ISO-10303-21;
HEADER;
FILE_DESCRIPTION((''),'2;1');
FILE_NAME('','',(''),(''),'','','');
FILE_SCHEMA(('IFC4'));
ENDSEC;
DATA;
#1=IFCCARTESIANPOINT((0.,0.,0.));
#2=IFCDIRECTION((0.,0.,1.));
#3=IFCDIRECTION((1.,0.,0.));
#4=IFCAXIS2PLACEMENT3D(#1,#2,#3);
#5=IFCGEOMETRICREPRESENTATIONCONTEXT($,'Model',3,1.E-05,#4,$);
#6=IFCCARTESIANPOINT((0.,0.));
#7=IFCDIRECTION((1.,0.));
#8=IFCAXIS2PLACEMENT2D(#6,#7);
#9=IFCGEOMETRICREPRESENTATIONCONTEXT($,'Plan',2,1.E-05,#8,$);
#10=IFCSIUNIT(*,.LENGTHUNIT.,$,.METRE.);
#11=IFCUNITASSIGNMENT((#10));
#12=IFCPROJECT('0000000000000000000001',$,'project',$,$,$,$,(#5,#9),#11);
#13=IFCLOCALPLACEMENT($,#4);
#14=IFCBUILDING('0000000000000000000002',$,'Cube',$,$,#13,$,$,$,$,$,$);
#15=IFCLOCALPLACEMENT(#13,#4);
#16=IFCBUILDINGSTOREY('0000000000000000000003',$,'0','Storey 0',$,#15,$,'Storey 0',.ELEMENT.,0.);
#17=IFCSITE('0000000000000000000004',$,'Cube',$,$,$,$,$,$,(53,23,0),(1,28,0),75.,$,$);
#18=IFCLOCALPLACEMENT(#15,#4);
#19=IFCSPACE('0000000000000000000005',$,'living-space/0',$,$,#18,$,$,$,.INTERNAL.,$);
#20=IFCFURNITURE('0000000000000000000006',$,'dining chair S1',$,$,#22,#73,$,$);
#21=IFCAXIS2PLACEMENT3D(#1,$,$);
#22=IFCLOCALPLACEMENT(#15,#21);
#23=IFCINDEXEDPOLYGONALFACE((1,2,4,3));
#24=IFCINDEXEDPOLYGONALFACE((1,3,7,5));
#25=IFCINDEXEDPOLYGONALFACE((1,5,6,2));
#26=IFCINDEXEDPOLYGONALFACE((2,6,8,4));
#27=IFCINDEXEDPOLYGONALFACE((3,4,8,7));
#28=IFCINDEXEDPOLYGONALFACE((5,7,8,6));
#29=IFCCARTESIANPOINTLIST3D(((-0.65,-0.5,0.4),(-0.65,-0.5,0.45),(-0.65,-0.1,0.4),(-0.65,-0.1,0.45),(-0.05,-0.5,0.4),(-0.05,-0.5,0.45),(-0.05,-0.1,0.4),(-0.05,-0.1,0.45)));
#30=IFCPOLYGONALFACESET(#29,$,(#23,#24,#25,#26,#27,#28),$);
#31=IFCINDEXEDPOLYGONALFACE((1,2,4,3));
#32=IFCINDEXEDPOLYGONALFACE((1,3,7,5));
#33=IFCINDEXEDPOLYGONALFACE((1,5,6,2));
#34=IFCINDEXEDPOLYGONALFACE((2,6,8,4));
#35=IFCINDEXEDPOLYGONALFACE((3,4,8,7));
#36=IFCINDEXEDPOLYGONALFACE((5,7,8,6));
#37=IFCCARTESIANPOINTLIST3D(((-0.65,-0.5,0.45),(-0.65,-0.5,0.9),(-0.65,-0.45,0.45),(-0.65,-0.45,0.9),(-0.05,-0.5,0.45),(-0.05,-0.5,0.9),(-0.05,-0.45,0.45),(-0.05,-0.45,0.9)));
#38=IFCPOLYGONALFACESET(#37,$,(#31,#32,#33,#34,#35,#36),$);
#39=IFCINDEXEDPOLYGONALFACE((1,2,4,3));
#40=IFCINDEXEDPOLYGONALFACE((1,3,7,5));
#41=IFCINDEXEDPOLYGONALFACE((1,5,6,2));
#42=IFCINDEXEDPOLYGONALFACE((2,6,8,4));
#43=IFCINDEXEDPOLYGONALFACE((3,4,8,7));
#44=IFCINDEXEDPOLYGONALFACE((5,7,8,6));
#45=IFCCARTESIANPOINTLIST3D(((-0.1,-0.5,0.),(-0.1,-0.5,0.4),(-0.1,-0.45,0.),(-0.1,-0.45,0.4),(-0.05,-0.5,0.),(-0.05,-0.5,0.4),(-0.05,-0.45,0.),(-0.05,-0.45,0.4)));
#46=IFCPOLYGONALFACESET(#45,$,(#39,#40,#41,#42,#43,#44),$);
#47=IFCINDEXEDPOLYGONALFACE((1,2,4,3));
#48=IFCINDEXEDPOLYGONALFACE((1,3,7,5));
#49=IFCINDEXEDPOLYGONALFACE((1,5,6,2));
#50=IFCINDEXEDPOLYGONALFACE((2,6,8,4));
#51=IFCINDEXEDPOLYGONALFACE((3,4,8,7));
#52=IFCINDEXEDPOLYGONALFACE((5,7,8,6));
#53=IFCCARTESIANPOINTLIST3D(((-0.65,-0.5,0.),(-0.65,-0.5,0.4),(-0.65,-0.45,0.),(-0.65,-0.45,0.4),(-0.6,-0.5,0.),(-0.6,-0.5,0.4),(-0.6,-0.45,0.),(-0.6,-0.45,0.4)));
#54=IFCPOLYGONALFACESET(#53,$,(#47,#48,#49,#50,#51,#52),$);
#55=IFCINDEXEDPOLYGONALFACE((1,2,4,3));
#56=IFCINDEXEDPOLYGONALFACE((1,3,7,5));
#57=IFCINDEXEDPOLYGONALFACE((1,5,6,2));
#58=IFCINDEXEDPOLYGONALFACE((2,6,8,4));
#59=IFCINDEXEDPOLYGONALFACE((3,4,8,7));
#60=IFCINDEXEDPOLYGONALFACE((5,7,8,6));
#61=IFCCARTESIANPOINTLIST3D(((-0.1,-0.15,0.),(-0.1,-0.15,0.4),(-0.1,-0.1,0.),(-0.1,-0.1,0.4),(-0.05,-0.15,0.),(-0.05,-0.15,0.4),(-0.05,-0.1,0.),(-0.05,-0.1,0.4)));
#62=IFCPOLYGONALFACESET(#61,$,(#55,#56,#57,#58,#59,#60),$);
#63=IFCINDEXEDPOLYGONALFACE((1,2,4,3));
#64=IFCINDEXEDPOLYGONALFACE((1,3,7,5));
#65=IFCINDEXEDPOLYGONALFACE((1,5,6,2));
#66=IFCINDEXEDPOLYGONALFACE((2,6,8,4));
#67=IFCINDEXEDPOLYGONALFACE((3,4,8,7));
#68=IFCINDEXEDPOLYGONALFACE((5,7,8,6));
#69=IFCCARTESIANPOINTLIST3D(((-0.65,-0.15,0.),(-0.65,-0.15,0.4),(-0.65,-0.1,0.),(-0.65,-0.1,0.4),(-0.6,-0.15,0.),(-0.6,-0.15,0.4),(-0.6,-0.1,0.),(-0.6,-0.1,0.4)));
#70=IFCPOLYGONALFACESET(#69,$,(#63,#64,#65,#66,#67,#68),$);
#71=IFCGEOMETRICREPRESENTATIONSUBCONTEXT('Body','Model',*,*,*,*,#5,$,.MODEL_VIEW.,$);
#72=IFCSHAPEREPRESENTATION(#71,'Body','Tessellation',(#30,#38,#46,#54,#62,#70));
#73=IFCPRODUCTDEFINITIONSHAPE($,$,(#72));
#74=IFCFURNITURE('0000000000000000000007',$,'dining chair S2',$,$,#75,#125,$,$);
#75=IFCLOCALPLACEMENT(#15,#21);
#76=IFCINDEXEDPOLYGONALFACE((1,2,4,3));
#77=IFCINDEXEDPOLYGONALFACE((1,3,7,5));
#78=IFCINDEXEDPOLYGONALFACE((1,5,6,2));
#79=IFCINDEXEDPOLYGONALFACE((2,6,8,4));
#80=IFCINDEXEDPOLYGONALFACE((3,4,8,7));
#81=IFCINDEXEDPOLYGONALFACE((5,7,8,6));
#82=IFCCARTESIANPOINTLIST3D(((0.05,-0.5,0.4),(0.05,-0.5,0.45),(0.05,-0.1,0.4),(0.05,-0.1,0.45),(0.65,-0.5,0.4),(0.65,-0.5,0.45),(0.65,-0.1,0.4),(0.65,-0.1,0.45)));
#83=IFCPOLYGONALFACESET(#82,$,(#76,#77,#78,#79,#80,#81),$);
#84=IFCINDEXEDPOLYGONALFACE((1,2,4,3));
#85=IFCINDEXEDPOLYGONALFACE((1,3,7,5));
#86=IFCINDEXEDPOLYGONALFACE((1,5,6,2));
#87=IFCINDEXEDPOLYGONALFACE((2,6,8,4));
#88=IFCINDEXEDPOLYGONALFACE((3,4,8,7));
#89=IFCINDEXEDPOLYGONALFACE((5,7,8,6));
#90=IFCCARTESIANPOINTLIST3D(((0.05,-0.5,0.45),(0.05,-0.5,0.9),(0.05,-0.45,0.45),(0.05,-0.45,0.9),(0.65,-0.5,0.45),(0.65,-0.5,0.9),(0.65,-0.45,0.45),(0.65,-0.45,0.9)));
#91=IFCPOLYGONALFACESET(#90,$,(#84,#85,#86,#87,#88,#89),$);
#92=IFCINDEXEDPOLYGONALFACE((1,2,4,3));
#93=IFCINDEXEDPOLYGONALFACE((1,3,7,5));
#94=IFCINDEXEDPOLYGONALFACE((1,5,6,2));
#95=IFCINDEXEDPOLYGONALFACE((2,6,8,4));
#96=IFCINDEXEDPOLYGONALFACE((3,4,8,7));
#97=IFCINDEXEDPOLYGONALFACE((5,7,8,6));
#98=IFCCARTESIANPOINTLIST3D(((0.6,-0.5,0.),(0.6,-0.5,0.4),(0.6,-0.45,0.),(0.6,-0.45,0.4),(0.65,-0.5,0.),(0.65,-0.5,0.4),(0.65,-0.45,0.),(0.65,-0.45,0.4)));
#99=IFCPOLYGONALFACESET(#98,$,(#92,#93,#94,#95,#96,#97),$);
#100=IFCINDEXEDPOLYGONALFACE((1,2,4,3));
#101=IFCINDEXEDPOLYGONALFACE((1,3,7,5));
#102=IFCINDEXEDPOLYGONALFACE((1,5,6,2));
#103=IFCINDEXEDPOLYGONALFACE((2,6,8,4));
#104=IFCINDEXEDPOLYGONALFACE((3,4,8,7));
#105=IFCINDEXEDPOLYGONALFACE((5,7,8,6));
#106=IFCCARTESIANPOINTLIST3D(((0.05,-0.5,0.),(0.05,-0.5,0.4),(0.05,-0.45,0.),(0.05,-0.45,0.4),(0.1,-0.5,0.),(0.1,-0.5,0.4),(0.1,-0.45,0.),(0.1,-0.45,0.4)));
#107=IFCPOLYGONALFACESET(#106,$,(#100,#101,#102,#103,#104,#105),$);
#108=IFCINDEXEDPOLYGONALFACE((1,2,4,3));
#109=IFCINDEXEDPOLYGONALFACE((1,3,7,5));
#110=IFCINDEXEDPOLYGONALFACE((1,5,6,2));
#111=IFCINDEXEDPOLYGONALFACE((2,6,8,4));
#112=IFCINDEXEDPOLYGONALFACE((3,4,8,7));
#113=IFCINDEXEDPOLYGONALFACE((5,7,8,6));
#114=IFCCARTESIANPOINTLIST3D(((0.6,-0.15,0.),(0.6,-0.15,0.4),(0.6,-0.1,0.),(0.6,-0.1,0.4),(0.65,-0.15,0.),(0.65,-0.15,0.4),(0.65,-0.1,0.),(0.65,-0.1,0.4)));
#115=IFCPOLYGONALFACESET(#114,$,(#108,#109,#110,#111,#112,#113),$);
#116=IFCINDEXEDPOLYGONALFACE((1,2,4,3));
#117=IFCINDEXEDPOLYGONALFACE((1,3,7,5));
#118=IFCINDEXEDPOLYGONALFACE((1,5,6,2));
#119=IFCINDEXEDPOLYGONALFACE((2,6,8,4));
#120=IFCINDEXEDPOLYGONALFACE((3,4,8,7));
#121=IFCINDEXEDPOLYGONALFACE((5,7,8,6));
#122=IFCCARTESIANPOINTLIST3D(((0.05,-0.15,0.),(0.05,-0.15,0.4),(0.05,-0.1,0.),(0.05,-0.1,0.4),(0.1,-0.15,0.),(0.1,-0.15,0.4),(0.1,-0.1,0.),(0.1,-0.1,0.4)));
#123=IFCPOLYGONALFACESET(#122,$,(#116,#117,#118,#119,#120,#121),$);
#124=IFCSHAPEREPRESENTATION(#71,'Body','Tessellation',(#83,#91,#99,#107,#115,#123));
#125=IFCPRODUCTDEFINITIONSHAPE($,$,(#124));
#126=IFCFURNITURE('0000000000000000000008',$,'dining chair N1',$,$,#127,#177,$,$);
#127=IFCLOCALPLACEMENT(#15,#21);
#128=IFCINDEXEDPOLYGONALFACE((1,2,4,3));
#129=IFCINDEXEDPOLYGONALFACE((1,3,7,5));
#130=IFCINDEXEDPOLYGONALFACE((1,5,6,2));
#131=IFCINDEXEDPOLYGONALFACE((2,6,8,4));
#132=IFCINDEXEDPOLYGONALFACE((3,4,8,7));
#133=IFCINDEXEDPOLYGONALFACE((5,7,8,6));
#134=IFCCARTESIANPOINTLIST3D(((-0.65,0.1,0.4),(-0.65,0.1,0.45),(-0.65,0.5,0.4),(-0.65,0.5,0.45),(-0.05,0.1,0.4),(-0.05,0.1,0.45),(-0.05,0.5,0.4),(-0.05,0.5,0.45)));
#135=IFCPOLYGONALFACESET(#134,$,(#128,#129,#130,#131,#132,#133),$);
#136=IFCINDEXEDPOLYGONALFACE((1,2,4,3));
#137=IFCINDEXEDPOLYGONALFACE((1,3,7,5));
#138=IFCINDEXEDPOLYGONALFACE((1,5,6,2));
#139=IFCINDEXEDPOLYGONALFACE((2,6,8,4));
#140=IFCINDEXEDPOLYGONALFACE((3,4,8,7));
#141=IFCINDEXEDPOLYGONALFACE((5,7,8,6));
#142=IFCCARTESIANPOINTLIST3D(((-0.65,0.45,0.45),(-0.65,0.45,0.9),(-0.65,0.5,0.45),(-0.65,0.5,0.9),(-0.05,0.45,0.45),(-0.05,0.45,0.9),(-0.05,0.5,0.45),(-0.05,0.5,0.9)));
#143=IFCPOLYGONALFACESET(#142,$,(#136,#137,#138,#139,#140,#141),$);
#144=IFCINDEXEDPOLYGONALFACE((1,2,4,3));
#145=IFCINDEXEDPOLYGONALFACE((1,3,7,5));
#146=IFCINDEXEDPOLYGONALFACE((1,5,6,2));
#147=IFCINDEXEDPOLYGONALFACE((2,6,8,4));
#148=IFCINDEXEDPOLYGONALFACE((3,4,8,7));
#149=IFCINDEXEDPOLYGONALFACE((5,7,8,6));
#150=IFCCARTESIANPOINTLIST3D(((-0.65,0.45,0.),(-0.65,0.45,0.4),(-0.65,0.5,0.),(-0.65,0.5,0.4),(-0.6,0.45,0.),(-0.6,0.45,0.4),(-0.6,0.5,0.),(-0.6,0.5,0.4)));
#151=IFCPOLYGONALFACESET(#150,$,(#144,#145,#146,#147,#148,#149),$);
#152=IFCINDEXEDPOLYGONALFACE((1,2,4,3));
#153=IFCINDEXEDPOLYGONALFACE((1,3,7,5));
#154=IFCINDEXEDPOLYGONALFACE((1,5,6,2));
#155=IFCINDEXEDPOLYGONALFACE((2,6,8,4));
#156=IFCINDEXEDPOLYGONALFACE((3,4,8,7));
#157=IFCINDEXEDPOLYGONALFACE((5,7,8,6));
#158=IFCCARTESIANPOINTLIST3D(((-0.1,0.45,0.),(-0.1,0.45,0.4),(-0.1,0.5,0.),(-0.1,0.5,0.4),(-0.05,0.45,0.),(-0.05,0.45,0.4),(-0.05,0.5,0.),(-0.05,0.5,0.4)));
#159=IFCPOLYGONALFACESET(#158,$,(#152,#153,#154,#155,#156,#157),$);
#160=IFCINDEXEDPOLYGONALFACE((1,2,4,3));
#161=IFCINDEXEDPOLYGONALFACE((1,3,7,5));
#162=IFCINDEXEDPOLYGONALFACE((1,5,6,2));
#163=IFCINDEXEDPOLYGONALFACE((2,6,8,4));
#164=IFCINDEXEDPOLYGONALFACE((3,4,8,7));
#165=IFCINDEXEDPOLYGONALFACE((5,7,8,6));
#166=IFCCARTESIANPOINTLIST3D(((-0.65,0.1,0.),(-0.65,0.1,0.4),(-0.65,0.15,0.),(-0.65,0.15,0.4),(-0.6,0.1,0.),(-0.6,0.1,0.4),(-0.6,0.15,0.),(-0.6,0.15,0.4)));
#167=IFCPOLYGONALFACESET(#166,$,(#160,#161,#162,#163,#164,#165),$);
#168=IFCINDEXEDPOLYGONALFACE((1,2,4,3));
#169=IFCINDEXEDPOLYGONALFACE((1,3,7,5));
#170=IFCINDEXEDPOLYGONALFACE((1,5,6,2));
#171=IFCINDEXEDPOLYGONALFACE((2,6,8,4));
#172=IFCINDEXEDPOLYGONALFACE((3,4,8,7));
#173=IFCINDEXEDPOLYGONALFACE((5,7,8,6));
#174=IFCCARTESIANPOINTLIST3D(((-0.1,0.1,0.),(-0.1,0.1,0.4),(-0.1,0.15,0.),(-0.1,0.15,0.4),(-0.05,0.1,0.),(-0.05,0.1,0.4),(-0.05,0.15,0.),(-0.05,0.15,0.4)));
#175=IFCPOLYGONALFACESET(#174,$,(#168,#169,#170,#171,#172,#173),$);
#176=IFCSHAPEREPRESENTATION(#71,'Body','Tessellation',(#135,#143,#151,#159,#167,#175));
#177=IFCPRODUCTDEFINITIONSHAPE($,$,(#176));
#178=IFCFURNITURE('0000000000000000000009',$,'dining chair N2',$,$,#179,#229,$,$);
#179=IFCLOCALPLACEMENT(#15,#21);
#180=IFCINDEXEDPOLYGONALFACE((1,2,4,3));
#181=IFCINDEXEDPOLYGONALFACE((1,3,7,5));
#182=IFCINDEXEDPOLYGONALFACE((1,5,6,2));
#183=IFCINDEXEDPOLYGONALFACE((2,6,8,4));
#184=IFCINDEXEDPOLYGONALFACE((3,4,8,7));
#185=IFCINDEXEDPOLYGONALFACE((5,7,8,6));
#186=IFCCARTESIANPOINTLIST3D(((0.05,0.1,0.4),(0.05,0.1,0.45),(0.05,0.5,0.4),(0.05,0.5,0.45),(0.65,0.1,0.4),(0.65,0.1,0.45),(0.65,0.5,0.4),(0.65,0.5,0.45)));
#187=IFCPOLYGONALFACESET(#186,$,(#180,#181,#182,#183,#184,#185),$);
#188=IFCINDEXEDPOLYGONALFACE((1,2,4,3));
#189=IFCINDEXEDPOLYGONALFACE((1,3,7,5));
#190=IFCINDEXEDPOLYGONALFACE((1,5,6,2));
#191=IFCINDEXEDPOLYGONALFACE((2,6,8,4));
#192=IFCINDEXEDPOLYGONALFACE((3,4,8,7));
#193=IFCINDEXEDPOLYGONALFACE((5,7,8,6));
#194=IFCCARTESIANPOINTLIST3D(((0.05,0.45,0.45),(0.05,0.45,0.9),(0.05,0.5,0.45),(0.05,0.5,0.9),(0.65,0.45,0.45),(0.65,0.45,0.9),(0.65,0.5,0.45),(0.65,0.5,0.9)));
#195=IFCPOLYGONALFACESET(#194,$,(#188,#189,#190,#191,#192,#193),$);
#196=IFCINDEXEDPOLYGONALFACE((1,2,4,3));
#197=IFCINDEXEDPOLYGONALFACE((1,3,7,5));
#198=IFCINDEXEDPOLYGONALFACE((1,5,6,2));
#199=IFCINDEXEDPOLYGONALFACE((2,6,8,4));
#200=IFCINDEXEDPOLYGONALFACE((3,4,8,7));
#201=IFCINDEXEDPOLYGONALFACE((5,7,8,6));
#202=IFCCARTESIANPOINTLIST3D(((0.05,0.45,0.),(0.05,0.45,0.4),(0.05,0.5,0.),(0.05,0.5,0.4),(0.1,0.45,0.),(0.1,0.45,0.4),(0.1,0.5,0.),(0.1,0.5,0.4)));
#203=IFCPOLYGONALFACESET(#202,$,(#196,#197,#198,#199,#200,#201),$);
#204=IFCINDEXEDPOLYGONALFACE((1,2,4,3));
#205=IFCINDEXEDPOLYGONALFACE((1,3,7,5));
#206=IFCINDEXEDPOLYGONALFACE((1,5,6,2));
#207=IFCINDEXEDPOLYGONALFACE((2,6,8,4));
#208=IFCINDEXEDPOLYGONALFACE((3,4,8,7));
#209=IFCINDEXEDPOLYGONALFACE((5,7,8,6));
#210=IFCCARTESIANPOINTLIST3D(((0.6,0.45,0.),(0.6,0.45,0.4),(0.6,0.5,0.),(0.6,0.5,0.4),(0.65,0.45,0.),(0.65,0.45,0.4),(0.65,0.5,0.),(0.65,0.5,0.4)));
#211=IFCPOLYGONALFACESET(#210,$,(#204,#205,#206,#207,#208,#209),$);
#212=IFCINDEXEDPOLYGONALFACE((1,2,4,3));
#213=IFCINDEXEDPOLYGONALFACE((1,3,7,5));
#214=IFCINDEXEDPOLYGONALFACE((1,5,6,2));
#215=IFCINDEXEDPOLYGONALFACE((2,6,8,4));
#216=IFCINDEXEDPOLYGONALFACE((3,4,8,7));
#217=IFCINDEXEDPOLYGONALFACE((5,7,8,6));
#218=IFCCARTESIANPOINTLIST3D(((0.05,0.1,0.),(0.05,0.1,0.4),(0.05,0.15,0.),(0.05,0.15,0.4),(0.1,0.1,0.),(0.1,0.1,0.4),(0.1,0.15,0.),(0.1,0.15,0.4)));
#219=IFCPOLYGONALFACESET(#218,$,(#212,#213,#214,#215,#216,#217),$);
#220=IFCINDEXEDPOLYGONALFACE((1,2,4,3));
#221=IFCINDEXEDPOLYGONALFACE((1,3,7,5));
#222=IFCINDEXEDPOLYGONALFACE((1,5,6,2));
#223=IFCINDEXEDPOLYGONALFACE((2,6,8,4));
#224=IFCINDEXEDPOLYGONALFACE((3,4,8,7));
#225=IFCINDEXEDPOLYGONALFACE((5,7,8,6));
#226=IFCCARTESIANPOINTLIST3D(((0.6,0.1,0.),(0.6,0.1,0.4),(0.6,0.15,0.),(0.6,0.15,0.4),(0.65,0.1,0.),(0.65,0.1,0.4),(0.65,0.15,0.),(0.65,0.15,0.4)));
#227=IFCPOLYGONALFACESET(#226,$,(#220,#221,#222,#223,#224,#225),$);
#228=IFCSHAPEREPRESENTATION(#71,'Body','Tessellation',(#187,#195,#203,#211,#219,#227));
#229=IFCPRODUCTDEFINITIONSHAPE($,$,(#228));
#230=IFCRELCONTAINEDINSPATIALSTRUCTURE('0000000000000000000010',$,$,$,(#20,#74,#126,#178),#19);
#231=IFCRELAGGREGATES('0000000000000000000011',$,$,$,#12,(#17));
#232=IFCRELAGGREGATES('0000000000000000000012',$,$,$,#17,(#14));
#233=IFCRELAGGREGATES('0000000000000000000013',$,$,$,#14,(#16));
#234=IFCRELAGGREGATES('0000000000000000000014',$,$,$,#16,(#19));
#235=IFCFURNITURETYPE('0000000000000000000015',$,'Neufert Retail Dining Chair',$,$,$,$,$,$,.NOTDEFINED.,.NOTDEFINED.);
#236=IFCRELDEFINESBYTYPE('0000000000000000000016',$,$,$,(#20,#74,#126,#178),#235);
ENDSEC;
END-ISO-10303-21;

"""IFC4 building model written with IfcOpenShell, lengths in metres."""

from ifc_helpers import new_model, entity, si_unit, frame, origin_with_axes, origin_2d_with_axis, place, context, subcontext, project, spatial, line, indexed_curve, outline, extrude, shape, source, transform, mapped, type_object, type_shapes, element, save


model = new_model("IFC4")

# Units and contexts
model_context = context("Model", 3, precision=1e-05, world=origin_with_axes())
plan_context = context("Plan", 2, precision=1e-05, world=origin_2d_with_axis())
body_context_1 = subcontext(model_context, "Body", "Model", "MODEL_VIEW")
body_context_2 = subcontext(plan_context, "Body", "Plan", "PLAN_VIEW")
ifc_project = project(units=[si_unit("LENGTHUNIT", "METRE")], contexts=[model_context, plan_context])

# Site, building, storey
site = spatial("IfcSite", under=ifc_project, Name="Cube", RefLatitude=(53, 23, 0), RefLongitude=(1, 28, 0), RefElevation=75.0)
building_placement = place(None, origin_with_axes())
building = spatial("IfcBuilding", under=site, at=building_placement, Name="Cube")
storey_placement = place(building_placement, origin_with_axes())
storey = spatial("IfcBuildingStorey", under=building, at=storey_placement, Name="0", Description="Storey 0", LongName="Storey 0", CompositionType="ELEMENT", Elevation=0.0)

# Shared definitions
space_placement = place(storey_placement, origin_with_axes())
space = spatial("IfcSpace", under=storey, at=space_placement, Name="living-space/0", PredefinedType="INTERNAL")

# Furniture
furniture_type_1 = type_object("IfcFurnitureType", Name="Neufert Retail Dining Chair", AssemblyPlace="NOTDEFINED", PredefinedType="NOTDEFINED")
shared_shape_1 = source(origin_with_axes(), body_context_1, "Body", "SweptSolid", [
    extrude(outline(indexed_curve([(-0.3, 0.0), (0.3, 0.0), (0.3, -0.4), (-0.3, -0.4)], segments=[line(1, 2, 3, 4, 1)])), frame((0.0, 0.0, 0.45), z_axis=(0.0, 0.0, 1.0), x_axis=(1.0, 0.0, 0.0)), (0.0, 0.0, -1.0), 0.05),
    extrude(outline(indexed_curve([(-0.3, 0.0), (0.3, 0.0), (0.3, -0.05), (-0.3, -0.05)], segments=[line(1, 2, 3, 4, 1)])), frame((0.0, 0.0, 0.9), z_axis=(0.0, 0.0, 1.0), x_axis=(1.0, 0.0, 0.0)), (0.0, 0.0, -1.0), 0.45),
    extrude(outline(indexed_curve([(-0.3, 0.0), (-0.25, 0.0), (-0.25, -0.05), (-0.3, -0.05)], segments=[line(1, 2, 3, 4, 1)])), origin_with_axes(), (0.0, 0.0, 1.0), 0.4),
    extrude(outline(indexed_curve([(0.3, 0.0), (0.25, 0.0), (0.25, -0.05), (0.3, -0.05)], segments=[line(1, 2, 3, 4, 1)])), origin_with_axes(), (0.0, 0.0, 1.0), 0.4),
    extrude(outline(indexed_curve([(-0.3, -0.4), (-0.25, -0.4), (-0.25, -0.35), (-0.3, -0.35)], segments=[line(1, 2, 3, 4, 1)])), origin_with_axes(), (0.0, 0.0, 1.0), 0.4),
    extrude(outline(indexed_curve([(0.3, -0.4), (0.25, -0.4), (0.25, -0.35), (0.3, -0.35)], segments=[line(1, 2, 3, 4, 1)])), origin_with_axes(), (0.0, 0.0, 1.0), 0.4),
])
shared_shape_2 = source(origin_with_axes(), body_context_2, "Body", "Curve2D", [
    entity("IfcIndexedPolyCurve", entity("IfcCartesianPointList2D", [[-0.3, -0.4], [0.3, -0.4]])),
    entity("IfcIndexedPolyCurve", entity("IfcCartesianPointList2D", [[-0.3, -0.4], [-0.3, -0.3], [-0.2121, -0.0879], [0.0, 0.0], [0.2121, -0.0879], [0.3, -0.3], [0.3, -0.4]]), [entity("IfcLineIndex", [1, 2]), entity("IfcArcIndex", [2, 3, 4]), entity("IfcArcIndex", [4, 5, 6]), entity("IfcLineIndex", [6, 7])]),
    entity("IfcIndexedPolyCurve", entity("IfcCartesianPointList2D", [[-0.26, -0.4], [-0.26, -0.3], [-0.1838, -0.1162], [0.0, -0.04], [0.1838, -0.1162], [0.26, -0.3], [0.26, -0.4]]), [entity("IfcLineIndex", [1, 2]), entity("IfcArcIndex", [2, 3, 4]), entity("IfcArcIndex", [4, 5, 6]), entity("IfcLineIndex", [6, 7])]),
])
type_shapes(furniture_type_1, [shared_shape_1, shared_shape_2])
for number, where, z_axis, x_axis, name in (
    (1, (-0.35, -0.5, 0.0), (0.0, 0.0, 1.0), (-1.0, 0.0, 0.0), "dining chair S1"),
    (2, (0.35, -0.5, 0.0), (0.0, 0.0, 1.0), (-1.0, 0.0, 0.0), "dining chair S2"),
    (3, (-0.35, 0.5, 0.0), (0.0, 0.0, 1.0), (1.0, 0.0, 0.0), "dining chair N1"),
    (4, (0.35, 0.5, 0.0), (0.0, 0.0, 1.0), (1.0, 0.0, 0.0), "dining chair N2"),
):
    element("IfcFurniture", number, at=place(space_placement, frame(where, z_axis=z_axis, x_axis=x_axis)), inside=space, type_object=furniture_type_1, Name=name, shapes=[
        shape(body_context_1, "Body", "MappedRepresentation", [mapped(shared_shape_1, transform((0.0, 0.0, 0.0), x_axis=(1.0, 0.0, 0.0), y_axis=(0.0, 1.0, 0.0), z_axis=(0.0, 0.0, 1.0), scale=1.0))]),
        shape(body_context_2, "Body", "MappedRepresentation", [mapped(shared_shape_2, transform((0.0, 0.0, 0.0), x_axis=(1.0, 0.0, 0.0), y_axis=(0.0, 1.0, 0.0), z_axis=(0.0, 0.0, 1.0), scale=1.0))]),
    ])

save(model, "model.ifc")
